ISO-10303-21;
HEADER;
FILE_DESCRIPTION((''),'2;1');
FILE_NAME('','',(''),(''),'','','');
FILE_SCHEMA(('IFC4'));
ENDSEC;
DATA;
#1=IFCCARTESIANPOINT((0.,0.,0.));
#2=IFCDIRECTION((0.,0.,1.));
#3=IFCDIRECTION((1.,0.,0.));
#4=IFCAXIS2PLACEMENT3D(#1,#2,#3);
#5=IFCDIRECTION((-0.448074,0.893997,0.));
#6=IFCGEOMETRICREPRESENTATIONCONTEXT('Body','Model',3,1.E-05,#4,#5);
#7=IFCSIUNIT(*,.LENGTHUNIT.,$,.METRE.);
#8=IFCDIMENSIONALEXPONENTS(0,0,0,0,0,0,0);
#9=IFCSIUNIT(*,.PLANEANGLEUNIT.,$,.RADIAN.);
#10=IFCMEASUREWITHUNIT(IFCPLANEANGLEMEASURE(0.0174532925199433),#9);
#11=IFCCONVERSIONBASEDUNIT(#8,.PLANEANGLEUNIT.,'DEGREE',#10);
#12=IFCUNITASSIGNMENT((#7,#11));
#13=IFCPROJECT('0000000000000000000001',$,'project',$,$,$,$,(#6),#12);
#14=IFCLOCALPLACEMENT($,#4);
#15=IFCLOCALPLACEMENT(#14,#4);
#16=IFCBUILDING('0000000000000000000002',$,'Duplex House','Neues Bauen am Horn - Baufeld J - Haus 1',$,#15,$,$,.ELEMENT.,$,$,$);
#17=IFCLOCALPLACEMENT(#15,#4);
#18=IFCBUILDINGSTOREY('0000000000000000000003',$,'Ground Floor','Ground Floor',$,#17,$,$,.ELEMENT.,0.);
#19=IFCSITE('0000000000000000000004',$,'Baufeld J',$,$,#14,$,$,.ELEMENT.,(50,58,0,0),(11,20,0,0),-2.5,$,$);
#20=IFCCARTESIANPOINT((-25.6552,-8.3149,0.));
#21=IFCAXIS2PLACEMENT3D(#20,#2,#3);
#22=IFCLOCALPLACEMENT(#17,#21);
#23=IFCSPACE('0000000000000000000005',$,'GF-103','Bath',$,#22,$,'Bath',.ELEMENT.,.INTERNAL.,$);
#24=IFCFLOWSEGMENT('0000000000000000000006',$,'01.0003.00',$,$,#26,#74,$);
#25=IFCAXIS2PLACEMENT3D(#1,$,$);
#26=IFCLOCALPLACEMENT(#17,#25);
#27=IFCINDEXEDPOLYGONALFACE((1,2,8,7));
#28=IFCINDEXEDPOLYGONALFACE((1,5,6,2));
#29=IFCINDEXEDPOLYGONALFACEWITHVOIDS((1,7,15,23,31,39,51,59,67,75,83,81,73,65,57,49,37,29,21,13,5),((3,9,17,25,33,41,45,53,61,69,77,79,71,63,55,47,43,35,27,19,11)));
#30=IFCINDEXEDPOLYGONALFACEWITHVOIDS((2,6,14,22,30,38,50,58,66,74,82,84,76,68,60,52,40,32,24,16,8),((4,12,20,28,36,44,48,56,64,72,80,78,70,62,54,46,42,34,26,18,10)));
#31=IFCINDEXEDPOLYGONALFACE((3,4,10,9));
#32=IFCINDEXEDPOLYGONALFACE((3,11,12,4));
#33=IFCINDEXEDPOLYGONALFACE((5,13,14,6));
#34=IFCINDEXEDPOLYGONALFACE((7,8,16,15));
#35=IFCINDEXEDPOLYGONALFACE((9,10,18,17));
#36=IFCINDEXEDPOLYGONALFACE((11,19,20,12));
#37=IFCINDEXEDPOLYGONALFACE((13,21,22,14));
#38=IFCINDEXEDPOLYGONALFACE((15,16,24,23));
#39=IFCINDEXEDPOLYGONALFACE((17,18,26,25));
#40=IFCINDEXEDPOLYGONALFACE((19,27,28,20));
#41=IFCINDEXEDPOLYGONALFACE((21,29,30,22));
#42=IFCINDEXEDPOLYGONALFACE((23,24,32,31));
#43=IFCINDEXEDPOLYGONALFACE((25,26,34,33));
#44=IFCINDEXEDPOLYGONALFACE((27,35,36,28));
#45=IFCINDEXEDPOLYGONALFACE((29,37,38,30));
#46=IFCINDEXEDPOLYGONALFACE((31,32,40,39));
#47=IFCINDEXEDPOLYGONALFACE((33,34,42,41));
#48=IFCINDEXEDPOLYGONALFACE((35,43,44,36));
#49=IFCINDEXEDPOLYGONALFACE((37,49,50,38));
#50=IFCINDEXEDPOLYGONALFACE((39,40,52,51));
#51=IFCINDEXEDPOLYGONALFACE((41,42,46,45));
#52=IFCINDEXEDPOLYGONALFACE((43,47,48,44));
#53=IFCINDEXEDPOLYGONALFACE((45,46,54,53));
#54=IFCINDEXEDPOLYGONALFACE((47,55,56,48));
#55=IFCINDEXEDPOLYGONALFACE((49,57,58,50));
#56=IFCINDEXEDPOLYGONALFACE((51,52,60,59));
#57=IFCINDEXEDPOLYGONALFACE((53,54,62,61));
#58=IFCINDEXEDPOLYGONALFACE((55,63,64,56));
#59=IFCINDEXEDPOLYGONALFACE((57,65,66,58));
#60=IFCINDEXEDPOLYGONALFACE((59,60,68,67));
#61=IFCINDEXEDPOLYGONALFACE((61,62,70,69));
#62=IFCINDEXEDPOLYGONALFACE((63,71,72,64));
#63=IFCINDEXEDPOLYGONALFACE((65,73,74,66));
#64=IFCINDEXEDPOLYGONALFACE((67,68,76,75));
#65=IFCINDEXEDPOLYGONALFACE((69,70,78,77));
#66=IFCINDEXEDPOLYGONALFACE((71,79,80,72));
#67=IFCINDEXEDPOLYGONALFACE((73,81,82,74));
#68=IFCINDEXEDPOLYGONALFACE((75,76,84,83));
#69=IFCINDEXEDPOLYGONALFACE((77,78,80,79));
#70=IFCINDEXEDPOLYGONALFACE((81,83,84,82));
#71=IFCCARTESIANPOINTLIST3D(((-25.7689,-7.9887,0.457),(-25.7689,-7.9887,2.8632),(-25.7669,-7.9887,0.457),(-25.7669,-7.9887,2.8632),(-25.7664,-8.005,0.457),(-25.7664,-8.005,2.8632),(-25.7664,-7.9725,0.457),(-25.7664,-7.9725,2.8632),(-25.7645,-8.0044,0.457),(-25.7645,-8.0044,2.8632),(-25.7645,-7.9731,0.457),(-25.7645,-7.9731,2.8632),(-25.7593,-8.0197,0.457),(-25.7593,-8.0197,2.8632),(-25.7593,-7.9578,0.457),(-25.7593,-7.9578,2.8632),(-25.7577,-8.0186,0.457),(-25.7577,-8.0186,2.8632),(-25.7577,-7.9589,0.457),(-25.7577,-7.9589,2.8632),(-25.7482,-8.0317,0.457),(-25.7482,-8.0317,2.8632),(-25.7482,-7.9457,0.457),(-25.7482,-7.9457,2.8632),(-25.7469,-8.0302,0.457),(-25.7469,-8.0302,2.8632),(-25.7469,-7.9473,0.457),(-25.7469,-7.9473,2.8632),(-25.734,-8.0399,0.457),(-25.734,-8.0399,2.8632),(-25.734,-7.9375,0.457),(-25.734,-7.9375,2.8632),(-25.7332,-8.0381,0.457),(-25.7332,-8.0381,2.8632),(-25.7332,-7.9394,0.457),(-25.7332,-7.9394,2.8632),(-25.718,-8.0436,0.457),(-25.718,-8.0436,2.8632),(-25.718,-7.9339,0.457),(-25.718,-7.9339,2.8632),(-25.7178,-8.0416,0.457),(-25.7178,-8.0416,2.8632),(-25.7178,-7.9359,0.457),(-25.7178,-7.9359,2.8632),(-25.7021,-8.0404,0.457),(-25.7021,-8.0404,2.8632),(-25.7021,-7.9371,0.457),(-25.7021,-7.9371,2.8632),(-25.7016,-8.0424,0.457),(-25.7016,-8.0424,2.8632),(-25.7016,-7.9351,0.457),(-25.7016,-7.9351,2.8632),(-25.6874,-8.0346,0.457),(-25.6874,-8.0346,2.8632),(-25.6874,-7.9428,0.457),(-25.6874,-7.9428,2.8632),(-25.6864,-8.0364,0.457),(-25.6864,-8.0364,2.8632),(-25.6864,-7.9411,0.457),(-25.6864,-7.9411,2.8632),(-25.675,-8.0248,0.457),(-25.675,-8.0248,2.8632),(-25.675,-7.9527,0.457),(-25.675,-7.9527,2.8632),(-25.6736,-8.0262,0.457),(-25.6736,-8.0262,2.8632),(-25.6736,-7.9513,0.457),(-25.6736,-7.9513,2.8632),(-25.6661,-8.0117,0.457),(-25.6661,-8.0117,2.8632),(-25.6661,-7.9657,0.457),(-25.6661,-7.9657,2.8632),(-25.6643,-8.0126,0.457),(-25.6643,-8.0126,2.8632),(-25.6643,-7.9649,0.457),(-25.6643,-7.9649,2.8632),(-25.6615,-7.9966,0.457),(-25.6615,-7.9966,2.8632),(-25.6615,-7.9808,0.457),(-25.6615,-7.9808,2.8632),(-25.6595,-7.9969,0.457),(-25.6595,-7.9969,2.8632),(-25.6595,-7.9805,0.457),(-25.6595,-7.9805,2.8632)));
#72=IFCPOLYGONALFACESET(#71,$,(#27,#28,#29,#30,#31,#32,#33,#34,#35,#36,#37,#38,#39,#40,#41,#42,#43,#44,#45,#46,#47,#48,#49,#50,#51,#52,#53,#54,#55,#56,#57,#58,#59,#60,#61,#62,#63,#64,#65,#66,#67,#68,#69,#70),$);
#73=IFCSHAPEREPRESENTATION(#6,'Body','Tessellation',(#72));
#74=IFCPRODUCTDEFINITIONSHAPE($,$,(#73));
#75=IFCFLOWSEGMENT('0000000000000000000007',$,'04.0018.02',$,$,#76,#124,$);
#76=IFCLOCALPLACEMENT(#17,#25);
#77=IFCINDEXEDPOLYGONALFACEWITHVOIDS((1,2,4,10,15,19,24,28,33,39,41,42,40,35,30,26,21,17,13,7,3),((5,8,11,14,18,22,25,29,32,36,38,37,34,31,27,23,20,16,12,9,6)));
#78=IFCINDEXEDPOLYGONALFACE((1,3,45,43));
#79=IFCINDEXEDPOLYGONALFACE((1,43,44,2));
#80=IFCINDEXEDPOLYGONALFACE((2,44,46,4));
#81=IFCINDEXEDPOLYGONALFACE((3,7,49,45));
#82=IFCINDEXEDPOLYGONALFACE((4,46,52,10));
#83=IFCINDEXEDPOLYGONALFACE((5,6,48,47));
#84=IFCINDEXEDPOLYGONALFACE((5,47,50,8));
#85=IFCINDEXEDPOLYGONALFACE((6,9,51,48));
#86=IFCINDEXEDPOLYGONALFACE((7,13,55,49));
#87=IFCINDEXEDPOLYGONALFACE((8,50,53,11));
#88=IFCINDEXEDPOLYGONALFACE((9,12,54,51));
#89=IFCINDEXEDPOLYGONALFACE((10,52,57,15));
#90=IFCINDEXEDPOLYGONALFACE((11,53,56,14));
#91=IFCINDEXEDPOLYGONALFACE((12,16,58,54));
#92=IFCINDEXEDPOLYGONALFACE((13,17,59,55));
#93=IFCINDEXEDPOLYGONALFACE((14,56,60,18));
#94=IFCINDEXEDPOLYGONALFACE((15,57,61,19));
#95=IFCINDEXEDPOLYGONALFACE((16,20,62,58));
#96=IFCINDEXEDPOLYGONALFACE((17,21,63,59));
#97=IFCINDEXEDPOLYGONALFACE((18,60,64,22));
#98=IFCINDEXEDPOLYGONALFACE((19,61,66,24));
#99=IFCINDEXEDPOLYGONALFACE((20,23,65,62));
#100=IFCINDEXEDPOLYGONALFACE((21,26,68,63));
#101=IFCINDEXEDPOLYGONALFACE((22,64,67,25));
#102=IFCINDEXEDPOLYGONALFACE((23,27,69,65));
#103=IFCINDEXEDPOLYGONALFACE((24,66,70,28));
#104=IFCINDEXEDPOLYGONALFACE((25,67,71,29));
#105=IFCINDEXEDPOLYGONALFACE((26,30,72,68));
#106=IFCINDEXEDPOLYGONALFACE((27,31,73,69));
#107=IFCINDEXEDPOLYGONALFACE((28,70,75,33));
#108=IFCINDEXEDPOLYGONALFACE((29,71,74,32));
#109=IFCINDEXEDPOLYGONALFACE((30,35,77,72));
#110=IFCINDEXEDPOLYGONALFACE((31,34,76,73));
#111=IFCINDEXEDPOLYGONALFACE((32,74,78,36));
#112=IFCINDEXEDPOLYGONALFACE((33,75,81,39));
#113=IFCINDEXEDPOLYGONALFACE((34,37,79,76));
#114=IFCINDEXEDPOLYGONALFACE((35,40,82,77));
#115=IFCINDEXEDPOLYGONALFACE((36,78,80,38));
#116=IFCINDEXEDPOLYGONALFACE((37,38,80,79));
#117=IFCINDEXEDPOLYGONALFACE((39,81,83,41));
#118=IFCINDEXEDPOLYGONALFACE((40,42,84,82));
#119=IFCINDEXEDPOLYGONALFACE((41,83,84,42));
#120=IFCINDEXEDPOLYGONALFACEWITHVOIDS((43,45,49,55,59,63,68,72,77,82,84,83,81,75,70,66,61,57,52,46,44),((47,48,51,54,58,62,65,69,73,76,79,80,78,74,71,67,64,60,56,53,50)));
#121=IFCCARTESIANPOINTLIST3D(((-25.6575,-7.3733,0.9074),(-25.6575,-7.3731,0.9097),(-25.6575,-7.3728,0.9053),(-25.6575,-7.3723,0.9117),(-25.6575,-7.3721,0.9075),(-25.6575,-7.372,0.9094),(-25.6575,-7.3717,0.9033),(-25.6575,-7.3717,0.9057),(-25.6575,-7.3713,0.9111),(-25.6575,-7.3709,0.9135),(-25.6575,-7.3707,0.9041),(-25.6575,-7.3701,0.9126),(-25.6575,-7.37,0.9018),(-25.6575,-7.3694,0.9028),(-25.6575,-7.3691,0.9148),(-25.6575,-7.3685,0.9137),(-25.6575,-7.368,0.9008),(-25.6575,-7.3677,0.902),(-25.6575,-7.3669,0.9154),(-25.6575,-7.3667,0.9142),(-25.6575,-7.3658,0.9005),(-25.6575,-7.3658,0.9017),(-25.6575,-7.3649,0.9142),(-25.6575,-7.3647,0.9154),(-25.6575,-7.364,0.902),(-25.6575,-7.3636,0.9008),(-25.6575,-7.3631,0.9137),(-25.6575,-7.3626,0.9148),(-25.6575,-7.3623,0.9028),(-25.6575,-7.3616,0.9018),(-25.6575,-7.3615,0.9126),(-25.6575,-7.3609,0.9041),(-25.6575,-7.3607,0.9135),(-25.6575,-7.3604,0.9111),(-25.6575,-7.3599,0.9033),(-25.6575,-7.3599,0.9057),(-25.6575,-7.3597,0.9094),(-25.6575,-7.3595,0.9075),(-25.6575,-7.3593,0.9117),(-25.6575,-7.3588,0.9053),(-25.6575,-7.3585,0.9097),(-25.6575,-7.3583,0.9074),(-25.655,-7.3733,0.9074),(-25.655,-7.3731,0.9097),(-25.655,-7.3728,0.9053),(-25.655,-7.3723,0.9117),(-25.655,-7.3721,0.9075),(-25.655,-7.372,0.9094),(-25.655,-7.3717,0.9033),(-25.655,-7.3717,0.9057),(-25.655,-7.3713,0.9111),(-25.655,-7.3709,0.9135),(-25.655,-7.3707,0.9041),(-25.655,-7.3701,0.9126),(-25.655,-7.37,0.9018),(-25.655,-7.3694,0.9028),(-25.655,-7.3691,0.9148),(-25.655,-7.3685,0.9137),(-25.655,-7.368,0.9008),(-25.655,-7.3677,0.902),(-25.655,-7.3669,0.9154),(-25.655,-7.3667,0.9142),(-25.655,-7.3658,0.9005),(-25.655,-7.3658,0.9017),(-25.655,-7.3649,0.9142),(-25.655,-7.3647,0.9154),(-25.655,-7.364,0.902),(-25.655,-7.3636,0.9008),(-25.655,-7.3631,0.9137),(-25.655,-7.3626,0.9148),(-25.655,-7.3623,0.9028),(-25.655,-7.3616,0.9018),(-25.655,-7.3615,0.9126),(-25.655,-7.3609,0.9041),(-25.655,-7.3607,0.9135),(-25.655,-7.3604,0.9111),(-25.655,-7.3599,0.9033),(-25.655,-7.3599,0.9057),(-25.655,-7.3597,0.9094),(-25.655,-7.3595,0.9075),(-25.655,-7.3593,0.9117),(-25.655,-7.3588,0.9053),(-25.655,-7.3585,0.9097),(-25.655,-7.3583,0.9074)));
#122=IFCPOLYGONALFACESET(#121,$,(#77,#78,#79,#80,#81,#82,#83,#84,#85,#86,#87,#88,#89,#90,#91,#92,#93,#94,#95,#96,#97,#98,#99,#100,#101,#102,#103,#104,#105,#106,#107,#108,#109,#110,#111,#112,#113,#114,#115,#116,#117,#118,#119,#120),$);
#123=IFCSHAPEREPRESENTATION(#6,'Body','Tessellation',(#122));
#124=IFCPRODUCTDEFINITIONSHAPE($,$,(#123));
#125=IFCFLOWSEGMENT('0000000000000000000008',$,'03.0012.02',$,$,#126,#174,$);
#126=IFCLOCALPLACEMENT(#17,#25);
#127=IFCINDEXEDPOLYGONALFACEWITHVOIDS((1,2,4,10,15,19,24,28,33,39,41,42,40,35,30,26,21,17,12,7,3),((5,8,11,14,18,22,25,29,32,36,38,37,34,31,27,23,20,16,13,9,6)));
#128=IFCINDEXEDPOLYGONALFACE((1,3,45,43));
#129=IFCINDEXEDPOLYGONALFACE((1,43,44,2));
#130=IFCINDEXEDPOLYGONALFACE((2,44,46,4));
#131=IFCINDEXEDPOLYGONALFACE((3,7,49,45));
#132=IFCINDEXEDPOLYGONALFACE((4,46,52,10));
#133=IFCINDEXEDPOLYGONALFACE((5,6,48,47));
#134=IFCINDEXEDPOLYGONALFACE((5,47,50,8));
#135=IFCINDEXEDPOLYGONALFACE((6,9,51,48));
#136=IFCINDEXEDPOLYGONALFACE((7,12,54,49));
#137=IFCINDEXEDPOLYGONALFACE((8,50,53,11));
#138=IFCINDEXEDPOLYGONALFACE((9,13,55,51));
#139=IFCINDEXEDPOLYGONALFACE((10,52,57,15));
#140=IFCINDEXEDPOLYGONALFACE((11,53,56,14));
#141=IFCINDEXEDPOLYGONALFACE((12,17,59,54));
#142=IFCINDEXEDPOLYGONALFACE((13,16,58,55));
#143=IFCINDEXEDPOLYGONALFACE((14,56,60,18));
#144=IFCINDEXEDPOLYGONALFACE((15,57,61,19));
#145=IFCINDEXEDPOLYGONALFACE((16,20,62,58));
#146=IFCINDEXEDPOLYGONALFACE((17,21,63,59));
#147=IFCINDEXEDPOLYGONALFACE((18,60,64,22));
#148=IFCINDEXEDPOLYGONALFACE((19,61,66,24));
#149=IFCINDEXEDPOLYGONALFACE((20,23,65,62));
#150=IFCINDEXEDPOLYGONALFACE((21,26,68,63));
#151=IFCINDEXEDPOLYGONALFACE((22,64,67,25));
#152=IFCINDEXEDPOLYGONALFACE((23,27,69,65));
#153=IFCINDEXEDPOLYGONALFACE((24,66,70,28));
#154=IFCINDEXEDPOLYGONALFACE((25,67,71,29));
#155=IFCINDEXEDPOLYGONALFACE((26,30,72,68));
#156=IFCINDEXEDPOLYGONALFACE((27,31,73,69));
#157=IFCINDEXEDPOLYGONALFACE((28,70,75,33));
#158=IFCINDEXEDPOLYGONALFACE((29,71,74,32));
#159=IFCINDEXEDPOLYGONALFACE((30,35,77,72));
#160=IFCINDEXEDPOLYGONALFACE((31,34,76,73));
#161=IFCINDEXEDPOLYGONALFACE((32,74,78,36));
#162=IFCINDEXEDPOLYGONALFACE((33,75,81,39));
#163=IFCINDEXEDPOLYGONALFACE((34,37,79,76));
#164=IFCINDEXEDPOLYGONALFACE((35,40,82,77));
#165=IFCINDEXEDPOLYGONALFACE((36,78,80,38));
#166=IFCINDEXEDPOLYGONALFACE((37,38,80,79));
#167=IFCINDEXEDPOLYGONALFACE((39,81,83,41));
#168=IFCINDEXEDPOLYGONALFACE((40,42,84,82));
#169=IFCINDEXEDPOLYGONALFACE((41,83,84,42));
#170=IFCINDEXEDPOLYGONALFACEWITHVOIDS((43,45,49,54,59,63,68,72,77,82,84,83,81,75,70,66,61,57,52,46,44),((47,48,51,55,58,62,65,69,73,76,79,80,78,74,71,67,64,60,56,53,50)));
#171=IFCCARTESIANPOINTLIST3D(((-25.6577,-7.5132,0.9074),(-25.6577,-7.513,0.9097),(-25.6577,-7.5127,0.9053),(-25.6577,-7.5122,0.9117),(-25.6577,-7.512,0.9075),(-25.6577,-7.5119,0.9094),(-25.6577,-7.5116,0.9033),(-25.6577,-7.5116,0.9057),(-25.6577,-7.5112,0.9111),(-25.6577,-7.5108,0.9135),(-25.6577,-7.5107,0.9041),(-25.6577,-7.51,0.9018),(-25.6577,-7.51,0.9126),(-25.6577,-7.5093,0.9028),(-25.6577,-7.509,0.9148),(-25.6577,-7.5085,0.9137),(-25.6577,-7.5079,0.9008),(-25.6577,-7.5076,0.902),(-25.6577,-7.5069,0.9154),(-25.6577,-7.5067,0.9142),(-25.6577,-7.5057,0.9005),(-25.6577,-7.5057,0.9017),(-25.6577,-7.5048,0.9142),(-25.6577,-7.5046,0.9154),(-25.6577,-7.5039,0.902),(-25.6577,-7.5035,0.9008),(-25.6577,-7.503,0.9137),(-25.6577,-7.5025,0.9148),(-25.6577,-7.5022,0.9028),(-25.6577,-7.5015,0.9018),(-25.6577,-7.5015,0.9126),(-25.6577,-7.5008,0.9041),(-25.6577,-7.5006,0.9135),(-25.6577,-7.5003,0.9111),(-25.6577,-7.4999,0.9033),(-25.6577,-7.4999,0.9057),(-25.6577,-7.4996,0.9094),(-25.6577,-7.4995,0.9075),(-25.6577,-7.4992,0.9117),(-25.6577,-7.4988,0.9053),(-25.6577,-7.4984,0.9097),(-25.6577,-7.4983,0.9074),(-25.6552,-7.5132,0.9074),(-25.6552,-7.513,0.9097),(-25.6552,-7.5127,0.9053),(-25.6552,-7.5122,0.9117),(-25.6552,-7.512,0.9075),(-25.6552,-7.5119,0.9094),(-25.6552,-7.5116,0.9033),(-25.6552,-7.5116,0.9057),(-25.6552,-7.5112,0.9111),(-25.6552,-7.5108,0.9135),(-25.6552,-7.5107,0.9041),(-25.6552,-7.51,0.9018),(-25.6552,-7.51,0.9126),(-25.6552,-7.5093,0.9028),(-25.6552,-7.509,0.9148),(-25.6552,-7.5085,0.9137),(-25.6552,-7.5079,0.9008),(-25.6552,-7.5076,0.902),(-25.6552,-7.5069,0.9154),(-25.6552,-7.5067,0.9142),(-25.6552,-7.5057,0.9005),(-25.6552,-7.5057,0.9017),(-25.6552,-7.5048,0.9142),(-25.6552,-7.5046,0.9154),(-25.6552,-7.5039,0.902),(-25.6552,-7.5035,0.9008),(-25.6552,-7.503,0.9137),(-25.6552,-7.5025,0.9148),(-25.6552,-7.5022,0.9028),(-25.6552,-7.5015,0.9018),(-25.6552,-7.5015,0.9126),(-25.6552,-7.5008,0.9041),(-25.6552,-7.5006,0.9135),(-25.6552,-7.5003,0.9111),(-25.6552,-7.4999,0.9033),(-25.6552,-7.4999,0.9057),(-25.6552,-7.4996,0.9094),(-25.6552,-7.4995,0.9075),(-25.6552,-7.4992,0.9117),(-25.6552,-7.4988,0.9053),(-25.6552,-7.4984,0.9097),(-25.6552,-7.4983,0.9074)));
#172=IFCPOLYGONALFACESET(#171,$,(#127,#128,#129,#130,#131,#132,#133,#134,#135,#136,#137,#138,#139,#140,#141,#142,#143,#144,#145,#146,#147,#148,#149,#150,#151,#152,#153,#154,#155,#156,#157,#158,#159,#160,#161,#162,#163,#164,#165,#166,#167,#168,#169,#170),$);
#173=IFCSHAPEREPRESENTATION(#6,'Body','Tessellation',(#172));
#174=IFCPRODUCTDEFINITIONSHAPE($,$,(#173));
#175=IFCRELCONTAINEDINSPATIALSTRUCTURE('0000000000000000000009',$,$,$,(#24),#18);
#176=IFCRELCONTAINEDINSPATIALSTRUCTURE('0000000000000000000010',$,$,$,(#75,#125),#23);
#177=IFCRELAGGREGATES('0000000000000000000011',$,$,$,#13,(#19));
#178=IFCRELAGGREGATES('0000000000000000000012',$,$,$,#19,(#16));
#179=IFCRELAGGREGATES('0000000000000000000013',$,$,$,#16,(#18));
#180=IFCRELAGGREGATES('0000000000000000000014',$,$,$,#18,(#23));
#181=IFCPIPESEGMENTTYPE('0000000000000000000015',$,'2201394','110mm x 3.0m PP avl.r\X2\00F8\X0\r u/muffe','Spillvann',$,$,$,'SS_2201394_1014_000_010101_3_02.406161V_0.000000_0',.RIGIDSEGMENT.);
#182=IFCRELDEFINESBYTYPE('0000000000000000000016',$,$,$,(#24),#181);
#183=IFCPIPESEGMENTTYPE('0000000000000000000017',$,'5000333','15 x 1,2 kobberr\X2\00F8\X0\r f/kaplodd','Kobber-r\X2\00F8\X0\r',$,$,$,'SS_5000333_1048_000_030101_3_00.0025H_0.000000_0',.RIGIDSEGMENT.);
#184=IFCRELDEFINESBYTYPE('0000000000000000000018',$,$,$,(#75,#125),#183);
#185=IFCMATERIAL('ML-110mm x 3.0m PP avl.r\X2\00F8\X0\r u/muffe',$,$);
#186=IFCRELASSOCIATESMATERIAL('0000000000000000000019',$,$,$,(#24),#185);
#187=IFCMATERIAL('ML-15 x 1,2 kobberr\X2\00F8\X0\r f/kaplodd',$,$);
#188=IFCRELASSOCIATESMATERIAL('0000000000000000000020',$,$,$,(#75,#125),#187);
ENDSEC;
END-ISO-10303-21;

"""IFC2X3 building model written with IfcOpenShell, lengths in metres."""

from ifc_helpers import new_model, entity, si_unit, converted_unit, direction, frame, origin_with_axes, origin_2d_with_axis, place, context, project, spatial, hollow_circle, extrude, material, type_object, element, save


model = new_model("IFC2X3")

# Units and contexts
model_context = context("Model", 3, precision=1e-05, world=origin_with_axes(), true_north=direction((-0.448074, 0.893997, 0.0)), identifier="Body")
ifc_project = project(units=[si_unit("LENGTHUNIT", "METRE"), converted_unit("PLANEANGLEUNIT", "DEGREE", entity("IfcPlaneAngleMeasure", 0.0174532925199433), si_unit("PLANEANGLEUNIT", "RADIAN"), dimensions=[0, 0, 0, 0, 0, 0, 0])], contexts=[model_context])

# Site, building, storey
site_placement = place(None, origin_with_axes())
site = spatial("IfcSite", under=ifc_project, at=site_placement, Name="Baufeld J", CompositionType="ELEMENT", RefLatitude=(50, 58, 0, 0), RefLongitude=(11, 20, 0, 0), RefElevation=-2.5)
building_placement = place(site_placement, origin_with_axes())
building = spatial("IfcBuilding", under=site, at=building_placement, Name="Duplex House", Description="Neues Bauen am Horn - Baufeld J - Haus 1", CompositionType="ELEMENT")
storey_placement = place(building_placement, origin_with_axes())
storey = spatial("IfcBuildingStorey", under=building, at=storey_placement, Name="Ground Floor", Description="Ground Floor", CompositionType="ELEMENT", Elevation=0.0)

# Flow segment
ifc_material_1 = material(Name="ML-110mm x 3.0m PP avl.rør u/muffe")
pipe_segment_type_1 = type_object("IfcPipeSegmentType", Name="2201394", Description="110mm x 3.0m PP avl.rør u/muffe", ApplicableOccurrence="Spillvann", ElementType="SS_2201394_1014_000_010101_3_02.406161V_0.000000_0", PredefinedType="RIGIDSEGMENT")
flow_segment_1_placement = place(storey_placement, frame((-25.7139, -7.9887, 2.8632), z_axis=(1.0, 0.0, 0.0), x_axis=(0.0, 0.0, -1.0)))
element("IfcFlowSegment", 1, at=flow_segment_1_placement, inside=storey, type_object=pipe_segment_type_1, material=ifc_material_1, Name="01.0003.00", context=model_context, shape_type="SweptSolid", body=[
    extrude(hollow_circle(Radius=0.055, WallThickness=0.002, at=origin_2d_with_axis()), frame((0.0, 0.0, 0.0), z_axis=(1.0, 0.0, 0.0), x_axis=(0.0, 0.0, -1.0)), (0.0, 0.0, 1.0), 2.4062),
])

# Shared definitions
space_1_placement = place(storey_placement, frame((-25.6552, -8.3149, 0.0), z_axis=(0.0, 0.0, 1.0), x_axis=(1.0, 0.0, 0.0)))
space_1 = spatial("IfcSpace", under=storey, at=space_1_placement, Name="GF-103", Description="Bath", LongName="Bath", CompositionType="ELEMENT", InteriorOrExteriorSpace="INTERNAL")

# Flow segments
ifc_material_2 = material(Name="ML-15 x 1,2 kobberrør f/kaplodd")
pipe_segment_type_2 = type_object("IfcPipeSegmentType", Name="5000333", Description="15 x 1,2 kobberrør f/kaplodd", ApplicableOccurrence="Kobber-rør", ElementType="SS_5000333_1048_000_030101_3_00.0025H_0.000000_0", PredefinedType="RIGIDSEGMENT")
flow_segment_2_placement = place(space_1_placement, frame((-0.0023, 0.9491, 0.908), z_axis=(0.0, 0.0, 1.0), x_axis=(1.0, 0.0, 0.0)))
element("IfcFlowSegment", 2, at=flow_segment_2_placement, inside=space_1, type_object=pipe_segment_type_2, material=ifc_material_2, Name="04.0018.02", context=model_context, shape_type="SweptSolid", body=[
    extrude(hollow_circle(Radius=0.0075, WallThickness=0.0012, at=origin_2d_with_axis()), frame((0.0, 0.0, 0.0), z_axis=(1.0, 0.0, 0.0), x_axis=(0.0, 0.0, -1.0)), (0.0, 0.0, 1.0), 0.0025),
])
flow_segment_3_placement = place(space_1_placement, frame((-0.0025, 0.8092, 0.908), z_axis=(0.0, 0.0, 1.0), x_axis=(1.0, 0.0, 0.0)))
element("IfcFlowSegment", 3, at=flow_segment_3_placement, inside=space_1, type_object=pipe_segment_type_2, material=ifc_material_2, Name="03.0012.02", context=model_context, shape_type="SweptSolid", body=[
    extrude(hollow_circle(Radius=0.0075, WallThickness=0.0012, at=origin_2d_with_axis()), frame((0.0, 0.0, 0.0), z_axis=(1.0, 0.0, 0.0), x_axis=(0.0, 0.0, -1.0)), (0.0, 0.0, 1.0), 0.0025),
])

save(model, "model.ifc")
